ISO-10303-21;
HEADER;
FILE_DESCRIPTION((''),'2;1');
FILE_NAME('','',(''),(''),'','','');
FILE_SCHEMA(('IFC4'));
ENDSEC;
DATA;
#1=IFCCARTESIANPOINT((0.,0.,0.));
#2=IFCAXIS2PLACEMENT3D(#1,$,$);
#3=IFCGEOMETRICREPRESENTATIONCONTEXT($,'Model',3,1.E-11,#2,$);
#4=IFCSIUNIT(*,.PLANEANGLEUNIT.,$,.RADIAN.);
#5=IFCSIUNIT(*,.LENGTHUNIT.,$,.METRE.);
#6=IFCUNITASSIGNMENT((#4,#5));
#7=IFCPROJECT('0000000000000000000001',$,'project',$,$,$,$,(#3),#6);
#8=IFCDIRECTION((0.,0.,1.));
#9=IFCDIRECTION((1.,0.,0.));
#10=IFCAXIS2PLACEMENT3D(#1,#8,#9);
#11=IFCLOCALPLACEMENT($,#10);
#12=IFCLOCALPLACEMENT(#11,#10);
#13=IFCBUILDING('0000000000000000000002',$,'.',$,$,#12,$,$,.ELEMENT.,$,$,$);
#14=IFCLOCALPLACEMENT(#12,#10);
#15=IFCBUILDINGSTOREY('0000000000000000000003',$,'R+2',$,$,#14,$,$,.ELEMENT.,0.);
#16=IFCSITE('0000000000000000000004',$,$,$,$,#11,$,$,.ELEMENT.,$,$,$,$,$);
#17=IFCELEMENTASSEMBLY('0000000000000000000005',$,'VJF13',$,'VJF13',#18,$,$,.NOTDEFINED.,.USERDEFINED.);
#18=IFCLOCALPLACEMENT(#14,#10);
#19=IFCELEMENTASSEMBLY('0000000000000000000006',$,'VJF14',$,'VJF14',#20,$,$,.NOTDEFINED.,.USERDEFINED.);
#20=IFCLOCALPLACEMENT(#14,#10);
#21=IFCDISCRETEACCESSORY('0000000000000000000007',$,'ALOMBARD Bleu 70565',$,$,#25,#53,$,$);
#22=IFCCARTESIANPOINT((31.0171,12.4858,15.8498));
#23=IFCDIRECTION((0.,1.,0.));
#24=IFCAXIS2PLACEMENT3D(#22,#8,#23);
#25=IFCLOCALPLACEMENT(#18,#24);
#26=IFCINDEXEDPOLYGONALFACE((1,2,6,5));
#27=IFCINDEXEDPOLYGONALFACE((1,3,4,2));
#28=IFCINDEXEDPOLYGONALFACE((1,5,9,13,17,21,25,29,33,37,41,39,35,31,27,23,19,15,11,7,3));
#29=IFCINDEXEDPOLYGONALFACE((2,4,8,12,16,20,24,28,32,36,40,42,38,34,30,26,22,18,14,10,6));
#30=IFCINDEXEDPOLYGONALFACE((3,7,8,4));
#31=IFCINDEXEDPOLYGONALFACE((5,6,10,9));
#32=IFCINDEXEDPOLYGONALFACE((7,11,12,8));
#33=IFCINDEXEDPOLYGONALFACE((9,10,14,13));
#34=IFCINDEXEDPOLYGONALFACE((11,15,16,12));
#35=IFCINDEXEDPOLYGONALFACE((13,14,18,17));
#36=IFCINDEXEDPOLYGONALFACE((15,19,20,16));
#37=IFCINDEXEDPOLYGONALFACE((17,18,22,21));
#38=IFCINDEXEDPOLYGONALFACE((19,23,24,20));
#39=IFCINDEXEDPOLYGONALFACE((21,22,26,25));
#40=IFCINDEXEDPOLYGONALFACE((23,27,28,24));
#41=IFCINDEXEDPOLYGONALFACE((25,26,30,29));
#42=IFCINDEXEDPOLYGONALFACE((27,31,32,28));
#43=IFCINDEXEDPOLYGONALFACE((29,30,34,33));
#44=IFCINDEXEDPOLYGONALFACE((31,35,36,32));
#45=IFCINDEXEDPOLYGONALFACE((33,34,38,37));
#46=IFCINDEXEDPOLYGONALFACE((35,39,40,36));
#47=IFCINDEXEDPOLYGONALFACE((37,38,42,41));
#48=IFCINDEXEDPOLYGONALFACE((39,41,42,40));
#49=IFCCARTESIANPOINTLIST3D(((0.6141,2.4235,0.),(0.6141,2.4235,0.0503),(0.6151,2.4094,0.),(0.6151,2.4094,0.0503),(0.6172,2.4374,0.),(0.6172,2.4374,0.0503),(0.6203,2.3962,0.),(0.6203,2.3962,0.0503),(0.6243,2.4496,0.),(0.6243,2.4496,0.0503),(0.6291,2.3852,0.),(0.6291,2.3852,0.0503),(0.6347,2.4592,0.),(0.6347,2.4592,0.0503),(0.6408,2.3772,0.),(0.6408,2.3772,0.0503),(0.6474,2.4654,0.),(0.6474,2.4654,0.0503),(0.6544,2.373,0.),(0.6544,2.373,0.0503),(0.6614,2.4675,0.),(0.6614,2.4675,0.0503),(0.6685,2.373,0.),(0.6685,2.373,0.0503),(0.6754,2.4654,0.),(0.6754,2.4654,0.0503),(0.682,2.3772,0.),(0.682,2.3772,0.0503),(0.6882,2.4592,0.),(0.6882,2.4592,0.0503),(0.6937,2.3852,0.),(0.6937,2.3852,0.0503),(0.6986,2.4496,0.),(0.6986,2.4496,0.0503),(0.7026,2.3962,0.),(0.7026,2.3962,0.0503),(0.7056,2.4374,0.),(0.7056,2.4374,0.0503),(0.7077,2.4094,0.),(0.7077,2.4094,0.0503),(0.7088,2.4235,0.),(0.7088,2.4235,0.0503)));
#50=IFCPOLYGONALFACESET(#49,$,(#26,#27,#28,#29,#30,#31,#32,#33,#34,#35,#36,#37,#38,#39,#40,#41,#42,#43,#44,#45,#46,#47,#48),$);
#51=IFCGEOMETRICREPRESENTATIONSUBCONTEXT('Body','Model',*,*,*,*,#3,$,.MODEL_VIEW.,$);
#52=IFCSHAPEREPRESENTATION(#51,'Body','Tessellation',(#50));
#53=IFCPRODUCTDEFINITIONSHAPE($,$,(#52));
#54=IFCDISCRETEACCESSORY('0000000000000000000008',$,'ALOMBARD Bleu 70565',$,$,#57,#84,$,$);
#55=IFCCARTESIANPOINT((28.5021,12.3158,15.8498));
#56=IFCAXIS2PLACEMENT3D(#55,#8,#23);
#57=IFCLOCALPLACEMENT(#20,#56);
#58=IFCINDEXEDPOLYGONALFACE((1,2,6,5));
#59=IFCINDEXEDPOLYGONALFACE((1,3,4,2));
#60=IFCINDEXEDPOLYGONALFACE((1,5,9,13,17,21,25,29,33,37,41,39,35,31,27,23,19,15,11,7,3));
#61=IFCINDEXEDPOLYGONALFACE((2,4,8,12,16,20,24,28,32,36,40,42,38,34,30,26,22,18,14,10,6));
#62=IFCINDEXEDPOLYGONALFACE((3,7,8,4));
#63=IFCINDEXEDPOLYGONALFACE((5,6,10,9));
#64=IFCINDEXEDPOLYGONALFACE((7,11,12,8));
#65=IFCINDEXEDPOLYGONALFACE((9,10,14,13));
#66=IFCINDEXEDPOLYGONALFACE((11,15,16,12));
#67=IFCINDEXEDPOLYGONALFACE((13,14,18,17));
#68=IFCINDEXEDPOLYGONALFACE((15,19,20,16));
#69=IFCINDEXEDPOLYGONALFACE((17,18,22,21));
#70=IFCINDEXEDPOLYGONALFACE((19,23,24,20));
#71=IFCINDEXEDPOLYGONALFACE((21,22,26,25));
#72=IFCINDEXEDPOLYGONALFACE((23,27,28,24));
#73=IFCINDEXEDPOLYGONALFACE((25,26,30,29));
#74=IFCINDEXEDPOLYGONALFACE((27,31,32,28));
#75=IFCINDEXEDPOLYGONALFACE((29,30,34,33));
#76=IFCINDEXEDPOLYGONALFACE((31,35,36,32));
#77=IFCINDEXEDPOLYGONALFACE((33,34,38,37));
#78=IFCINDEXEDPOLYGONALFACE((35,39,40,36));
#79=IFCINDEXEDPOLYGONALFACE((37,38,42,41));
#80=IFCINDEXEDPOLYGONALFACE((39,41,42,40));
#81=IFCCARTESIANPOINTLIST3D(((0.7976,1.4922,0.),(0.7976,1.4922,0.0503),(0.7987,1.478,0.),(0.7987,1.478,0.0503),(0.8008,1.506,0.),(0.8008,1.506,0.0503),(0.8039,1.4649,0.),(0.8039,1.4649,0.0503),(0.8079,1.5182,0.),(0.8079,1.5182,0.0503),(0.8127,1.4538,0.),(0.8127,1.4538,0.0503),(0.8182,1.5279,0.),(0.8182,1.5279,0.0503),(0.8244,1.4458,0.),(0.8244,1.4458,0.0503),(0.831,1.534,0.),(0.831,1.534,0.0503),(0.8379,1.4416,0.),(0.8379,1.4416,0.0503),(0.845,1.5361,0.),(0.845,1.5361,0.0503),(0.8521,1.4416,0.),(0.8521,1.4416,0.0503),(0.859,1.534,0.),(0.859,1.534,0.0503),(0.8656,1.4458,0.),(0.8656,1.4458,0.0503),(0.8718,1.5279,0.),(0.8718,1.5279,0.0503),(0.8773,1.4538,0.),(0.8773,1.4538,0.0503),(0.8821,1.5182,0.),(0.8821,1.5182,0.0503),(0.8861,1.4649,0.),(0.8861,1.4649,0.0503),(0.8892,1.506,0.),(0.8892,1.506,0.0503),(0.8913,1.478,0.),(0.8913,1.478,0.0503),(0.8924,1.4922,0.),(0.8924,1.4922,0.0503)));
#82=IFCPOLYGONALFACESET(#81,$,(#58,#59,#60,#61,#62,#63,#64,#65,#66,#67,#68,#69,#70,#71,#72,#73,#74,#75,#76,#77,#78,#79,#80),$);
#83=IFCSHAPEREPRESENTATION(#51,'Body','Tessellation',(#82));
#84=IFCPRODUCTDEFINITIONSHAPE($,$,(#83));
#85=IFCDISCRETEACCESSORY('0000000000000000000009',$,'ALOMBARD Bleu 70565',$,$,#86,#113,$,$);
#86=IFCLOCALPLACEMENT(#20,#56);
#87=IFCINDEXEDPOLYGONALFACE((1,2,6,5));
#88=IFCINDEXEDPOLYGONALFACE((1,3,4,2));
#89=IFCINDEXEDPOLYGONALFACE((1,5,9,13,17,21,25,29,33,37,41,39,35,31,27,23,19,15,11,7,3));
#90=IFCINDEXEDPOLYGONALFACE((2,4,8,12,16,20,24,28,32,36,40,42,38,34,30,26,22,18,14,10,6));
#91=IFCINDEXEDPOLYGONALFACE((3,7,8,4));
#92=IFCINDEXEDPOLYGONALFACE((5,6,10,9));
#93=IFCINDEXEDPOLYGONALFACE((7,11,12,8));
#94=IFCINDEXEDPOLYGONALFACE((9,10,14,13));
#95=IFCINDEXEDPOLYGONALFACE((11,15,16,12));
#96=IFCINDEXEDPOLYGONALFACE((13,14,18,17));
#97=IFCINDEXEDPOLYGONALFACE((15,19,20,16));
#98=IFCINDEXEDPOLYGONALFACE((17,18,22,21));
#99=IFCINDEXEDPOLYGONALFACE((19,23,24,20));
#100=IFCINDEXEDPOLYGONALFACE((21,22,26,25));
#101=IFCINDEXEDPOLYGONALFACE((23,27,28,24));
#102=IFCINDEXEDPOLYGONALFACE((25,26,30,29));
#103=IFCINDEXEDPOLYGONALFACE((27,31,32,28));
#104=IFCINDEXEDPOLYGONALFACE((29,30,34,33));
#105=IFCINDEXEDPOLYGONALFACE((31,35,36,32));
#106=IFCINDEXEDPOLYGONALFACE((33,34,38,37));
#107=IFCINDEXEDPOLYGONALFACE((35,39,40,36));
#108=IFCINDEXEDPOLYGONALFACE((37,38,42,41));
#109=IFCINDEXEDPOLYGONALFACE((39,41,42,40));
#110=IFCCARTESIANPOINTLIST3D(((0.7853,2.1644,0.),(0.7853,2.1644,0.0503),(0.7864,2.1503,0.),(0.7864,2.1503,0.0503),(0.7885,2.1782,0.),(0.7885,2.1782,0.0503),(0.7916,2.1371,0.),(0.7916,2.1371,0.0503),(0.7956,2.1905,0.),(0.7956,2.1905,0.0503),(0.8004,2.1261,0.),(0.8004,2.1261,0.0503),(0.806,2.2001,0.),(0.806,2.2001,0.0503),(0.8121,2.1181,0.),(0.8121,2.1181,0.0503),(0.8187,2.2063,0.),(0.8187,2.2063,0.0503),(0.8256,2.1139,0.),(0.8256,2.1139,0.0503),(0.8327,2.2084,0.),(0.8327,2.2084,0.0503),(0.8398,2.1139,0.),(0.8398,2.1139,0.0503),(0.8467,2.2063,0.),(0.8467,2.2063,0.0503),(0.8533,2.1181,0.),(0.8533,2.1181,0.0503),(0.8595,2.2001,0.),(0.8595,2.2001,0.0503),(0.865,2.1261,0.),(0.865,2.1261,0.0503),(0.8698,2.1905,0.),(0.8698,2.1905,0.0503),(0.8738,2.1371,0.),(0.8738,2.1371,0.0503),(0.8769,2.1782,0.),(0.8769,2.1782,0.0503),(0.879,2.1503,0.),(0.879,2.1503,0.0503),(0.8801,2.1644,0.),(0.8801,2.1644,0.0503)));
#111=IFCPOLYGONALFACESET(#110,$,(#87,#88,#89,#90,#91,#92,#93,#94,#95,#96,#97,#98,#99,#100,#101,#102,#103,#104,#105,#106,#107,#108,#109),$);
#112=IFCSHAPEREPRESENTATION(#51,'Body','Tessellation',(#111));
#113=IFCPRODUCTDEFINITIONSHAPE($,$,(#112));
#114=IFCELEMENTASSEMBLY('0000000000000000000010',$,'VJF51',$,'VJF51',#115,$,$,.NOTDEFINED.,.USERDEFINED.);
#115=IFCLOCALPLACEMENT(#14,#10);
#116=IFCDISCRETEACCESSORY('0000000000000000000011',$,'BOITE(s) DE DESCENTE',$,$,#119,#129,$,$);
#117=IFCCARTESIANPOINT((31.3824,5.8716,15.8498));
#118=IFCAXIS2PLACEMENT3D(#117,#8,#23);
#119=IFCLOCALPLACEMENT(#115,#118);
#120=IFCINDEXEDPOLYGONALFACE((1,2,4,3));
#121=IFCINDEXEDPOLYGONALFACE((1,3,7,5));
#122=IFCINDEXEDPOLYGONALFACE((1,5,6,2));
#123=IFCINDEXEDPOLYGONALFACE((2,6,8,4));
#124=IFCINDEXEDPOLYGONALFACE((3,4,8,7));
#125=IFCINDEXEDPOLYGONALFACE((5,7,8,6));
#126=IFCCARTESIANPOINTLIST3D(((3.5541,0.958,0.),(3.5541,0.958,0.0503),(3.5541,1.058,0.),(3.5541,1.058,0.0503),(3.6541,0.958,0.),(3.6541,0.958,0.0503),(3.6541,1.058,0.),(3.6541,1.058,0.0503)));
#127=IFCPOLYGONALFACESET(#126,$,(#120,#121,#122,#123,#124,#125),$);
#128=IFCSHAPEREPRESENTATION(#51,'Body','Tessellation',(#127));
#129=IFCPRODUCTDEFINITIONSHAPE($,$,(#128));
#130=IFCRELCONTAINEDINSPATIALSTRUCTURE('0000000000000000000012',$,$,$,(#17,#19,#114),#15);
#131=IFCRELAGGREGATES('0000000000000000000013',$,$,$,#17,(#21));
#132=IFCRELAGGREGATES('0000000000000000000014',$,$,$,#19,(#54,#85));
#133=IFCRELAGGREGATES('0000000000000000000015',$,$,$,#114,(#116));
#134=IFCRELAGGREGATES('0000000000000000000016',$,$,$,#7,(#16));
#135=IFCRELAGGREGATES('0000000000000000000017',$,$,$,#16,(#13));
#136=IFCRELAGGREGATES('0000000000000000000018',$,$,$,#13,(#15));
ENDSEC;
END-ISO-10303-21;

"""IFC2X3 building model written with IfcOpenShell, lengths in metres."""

from ifc_helpers import new_model, si_unit, frame, frame_2d, origin, origin_with_axes, place, context, subcontext, project, spatial, polyline, circle, outline, extrude, element, aggregate, save


model = new_model("IFC2X3")

# Units and contexts
model_context = context("Model", 3, precision=1e-11, world=origin())
body_context = subcontext(model_context, "Body", "Model", "MODEL_VIEW")
ifc_project = project(units=[si_unit("PLANEANGLEUNIT", "RADIAN"), si_unit("LENGTHUNIT", "METRE")], contexts=[model_context])

# Site, building, storey
site_placement = place(None, origin_with_axes())
site = spatial("IfcSite", under=ifc_project, at=site_placement, CompositionType="ELEMENT")
building_placement = place(site_placement, origin_with_axes())
building = spatial("IfcBuilding", under=site, at=building_placement, Name=".", CompositionType="ELEMENT")
storey_placement = place(building_placement, origin_with_axes())
storey = spatial("IfcBuildingStorey", under=building, at=storey_placement, Name="R+2", CompositionType="ELEMENT", Elevation=0.0)

# Element assembly
assembly_1_placement = place(storey_placement, origin_with_axes())
assembly_1 = element("IfcElementAssembly", 1, at=assembly_1_placement, inside=storey, Name="VJF13", ObjectType="VJF13", AssemblyPlace="NOTDEFINED", PredefinedType="USERDEFINED")

# Element assembly
assembly_2_placement = place(storey_placement, origin_with_axes())
assembly_2 = element("IfcElementAssembly", 2, at=assembly_2_placement, inside=storey, Name="VJF14", ObjectType="VJF14", AssemblyPlace="NOTDEFINED", PredefinedType="USERDEFINED")

# Discrete accessories
discrete_accessory_1_placement = place(assembly_1_placement, frame((31.0171, 12.4858, 15.8498), z_axis=(0.0, 0.0, 1.0), x_axis=(0.0, 1.0, 0.0)))
discrete_accessory_1 = element("IfcDiscreteAccessory", 3, at=discrete_accessory_1_placement, Name="ALOMBARD Bleu 70565", context=body_context, shape_type="SweptSolid", body=[
    extrude(circle(Radius=0.0475, at=frame_2d((2.42, -0.6614), x_axis=(1.0, 0.0))), frame((0.0, 0.0, 0.0), z_axis=(0.0, 0.0, 1.0), x_axis=(0.0, 1.0, 0.0)), (0.0, 0.0, 1.0), 0.0503),
])
aggregate(assembly_1, [discrete_accessory_1])
discrete_accessory_2_placement = place(assembly_2_placement, frame((28.5021, 12.3158, 15.8498), z_axis=(0.0, 0.0, 1.0), x_axis=(0.0, 1.0, 0.0)))
discrete_accessory_2 = element("IfcDiscreteAccessory", 4, at=discrete_accessory_2_placement, Name="ALOMBARD Bleu 70565", context=body_context, shape_type="SweptSolid", body=[
    extrude(circle(Radius=0.0475, at=frame_2d((1.4886, -0.845), x_axis=(1.0, 0.0))), frame((0.0, 0.0, 0.0), z_axis=(0.0, 0.0, 1.0), x_axis=(0.0, 1.0, 0.0)), (0.0, 0.0, 1.0), 0.0503),
])
discrete_accessory_3_placement = place(assembly_2_placement, frame((28.5021, 12.3158, 15.8498), z_axis=(0.0, 0.0, 1.0), x_axis=(0.0, 1.0, 0.0)))
discrete_accessory_3 = element("IfcDiscreteAccessory", 5, at=discrete_accessory_3_placement, Name="ALOMBARD Bleu 70565", context=body_context, shape_type="SweptSolid", body=[
    extrude(circle(Radius=0.0475, at=frame_2d((2.1609, -0.8327), x_axis=(1.0, 0.0))), frame((0.0, 0.0, 0.0), z_axis=(0.0, 0.0, 1.0), x_axis=(0.0, 1.0, 0.0)), (0.0, 0.0, 1.0), 0.0503),
])
aggregate(assembly_2, [discrete_accessory_2, discrete_accessory_3])

# Element assembly, discrete accessory
assembly_3_placement = place(storey_placement, origin_with_axes())
assembly_3 = element("IfcElementAssembly", 6, at=assembly_3_placement, inside=storey, Name="VJF51", ObjectType="VJF51", AssemblyPlace="NOTDEFINED", PredefinedType="USERDEFINED")
discrete_accessory_4_placement = place(assembly_3_placement, frame((31.3824, 5.8716, 15.8498), z_axis=(0.0, 0.0, 1.0), x_axis=(0.0, 1.0, 0.0)))
discrete_accessory_4 = element("IfcDiscreteAccessory", 7, at=discrete_accessory_4_placement, Name="BOITE(s) DE DESCENTE", context=body_context, shape_type="SweptSolid", body=[
    extrude(outline(polyline([(0.958, -3.5541), (0.958, -3.6541), (1.058, -3.6541), (1.058, -3.5541), (0.958, -3.5541)])), frame((0.0, 0.0, 0.0), z_axis=(0.0, 0.0, 1.0), x_axis=(0.0, 1.0, 0.0)), (0.0, 0.0, 1.0), 0.0503),
])
aggregate(assembly_3, [discrete_accessory_4])

save(model, "model.ifc")
